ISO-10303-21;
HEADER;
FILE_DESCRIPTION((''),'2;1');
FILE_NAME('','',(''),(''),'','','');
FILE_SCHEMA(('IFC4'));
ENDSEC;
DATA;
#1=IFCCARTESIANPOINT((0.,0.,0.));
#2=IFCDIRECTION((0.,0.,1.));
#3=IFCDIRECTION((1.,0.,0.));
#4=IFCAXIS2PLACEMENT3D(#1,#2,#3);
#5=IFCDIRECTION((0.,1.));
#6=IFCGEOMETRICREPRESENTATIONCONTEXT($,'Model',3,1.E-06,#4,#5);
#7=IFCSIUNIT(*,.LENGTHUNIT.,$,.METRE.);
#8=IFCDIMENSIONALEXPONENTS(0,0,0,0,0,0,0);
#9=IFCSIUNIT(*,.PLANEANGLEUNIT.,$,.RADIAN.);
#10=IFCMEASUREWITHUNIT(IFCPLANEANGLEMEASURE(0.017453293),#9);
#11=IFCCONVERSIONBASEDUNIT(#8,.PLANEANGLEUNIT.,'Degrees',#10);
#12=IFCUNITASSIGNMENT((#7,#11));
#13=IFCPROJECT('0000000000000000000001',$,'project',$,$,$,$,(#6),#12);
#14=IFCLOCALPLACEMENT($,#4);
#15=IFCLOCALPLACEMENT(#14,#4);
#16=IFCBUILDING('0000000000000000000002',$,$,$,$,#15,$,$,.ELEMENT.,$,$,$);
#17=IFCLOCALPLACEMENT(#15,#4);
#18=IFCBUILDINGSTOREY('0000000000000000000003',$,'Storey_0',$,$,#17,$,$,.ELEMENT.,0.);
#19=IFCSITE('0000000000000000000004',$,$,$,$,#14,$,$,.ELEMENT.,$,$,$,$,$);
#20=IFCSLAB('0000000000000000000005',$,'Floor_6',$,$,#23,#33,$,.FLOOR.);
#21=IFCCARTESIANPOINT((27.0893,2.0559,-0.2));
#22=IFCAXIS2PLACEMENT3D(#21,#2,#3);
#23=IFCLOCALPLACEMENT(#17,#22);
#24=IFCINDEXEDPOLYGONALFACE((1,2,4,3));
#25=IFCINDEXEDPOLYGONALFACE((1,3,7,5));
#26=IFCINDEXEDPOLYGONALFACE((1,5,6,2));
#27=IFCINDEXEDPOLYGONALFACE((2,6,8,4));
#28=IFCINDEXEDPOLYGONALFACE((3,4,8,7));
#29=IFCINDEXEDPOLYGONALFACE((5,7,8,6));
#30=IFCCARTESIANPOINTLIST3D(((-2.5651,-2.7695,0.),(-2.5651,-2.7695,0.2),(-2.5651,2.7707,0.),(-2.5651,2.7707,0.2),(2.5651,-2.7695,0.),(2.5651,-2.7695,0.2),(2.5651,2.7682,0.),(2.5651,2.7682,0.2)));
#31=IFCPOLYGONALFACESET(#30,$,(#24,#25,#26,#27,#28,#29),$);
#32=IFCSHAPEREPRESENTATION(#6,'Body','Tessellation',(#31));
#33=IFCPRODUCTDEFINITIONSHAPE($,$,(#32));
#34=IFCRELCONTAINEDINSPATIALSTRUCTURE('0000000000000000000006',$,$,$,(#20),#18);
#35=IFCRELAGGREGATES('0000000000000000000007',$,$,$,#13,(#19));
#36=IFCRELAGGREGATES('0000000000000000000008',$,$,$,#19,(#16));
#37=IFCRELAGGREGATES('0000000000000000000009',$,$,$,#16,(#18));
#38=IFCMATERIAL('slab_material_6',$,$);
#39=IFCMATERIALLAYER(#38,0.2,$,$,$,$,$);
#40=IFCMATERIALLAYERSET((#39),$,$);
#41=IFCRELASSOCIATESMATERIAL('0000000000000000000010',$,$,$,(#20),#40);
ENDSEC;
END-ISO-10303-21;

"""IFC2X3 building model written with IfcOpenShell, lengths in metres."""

from ifc_helpers import new_model, entity, si_unit, converted_unit, direction, frame, origin_with_axes, place, context, project, spatial, polyline, outline, extrude, material, layer, layer_set, layer_usage, element, save


model = new_model("IFC2X3")

# Units and contexts
model_context = context("Model", 3, precision=1e-06, world=origin_with_axes(), true_north=direction((0.0, 1.0)))
ifc_project = project(units=[si_unit("LENGTHUNIT", "METRE"), converted_unit("PLANEANGLEUNIT", "Degrees", entity("IfcPlaneAngleMeasure", 0.017453293), si_unit("PLANEANGLEUNIT", "RADIAN"), dimensions=[0, 0, 0, 0, 0, 0, 0])], contexts=[model_context])

# Site, building, storey
site_placement = place(None, origin_with_axes())
site = spatial("IfcSite", under=ifc_project, at=site_placement, CompositionType="ELEMENT")
building_placement = place(site_placement, origin_with_axes())
building = spatial("IfcBuilding", under=site, at=building_placement, CompositionType="ELEMENT")
storey_placement = place(building_placement, origin_with_axes())
storey = spatial("IfcBuildingStorey", under=building, at=storey_placement, Name="Storey_0", CompositionType="ELEMENT", Elevation=0.0)

# Slab
ifc_material_1 = material(Name="slab_material_6")
ifc_layer_1 = layer(ifc_material_1, 0.2)
ifc_layer_set_1 = layer_set([ifc_layer_1])
ifc_layer_usage_1 = layer_usage(ifc_layer_set_1, "AXIS3", "POSITIVE", 0.0)
slab_1_placement = place(storey_placement, frame((27.0893, 2.0559, -0.2), z_axis=(0.0, 0.0, 1.0), x_axis=(1.0, 0.0, 0.0)))
element("IfcSlab", 1, at=slab_1_placement, inside=storey, material=ifc_layer_usage_1, Name="Floor_6", PredefinedType="FLOOR", context=model_context, shape_type="SweptSolid", body=[
    extrude(outline(polyline([(-2.5651, 2.7707), (-2.5651, -2.7695), (2.5651, -2.7695), (2.5651, 2.7682), (-2.5651, 2.7707)])), origin_with_axes(), (0.0, 0.0, 1.0), 0.2),
])

save(model, "model.ifc")
